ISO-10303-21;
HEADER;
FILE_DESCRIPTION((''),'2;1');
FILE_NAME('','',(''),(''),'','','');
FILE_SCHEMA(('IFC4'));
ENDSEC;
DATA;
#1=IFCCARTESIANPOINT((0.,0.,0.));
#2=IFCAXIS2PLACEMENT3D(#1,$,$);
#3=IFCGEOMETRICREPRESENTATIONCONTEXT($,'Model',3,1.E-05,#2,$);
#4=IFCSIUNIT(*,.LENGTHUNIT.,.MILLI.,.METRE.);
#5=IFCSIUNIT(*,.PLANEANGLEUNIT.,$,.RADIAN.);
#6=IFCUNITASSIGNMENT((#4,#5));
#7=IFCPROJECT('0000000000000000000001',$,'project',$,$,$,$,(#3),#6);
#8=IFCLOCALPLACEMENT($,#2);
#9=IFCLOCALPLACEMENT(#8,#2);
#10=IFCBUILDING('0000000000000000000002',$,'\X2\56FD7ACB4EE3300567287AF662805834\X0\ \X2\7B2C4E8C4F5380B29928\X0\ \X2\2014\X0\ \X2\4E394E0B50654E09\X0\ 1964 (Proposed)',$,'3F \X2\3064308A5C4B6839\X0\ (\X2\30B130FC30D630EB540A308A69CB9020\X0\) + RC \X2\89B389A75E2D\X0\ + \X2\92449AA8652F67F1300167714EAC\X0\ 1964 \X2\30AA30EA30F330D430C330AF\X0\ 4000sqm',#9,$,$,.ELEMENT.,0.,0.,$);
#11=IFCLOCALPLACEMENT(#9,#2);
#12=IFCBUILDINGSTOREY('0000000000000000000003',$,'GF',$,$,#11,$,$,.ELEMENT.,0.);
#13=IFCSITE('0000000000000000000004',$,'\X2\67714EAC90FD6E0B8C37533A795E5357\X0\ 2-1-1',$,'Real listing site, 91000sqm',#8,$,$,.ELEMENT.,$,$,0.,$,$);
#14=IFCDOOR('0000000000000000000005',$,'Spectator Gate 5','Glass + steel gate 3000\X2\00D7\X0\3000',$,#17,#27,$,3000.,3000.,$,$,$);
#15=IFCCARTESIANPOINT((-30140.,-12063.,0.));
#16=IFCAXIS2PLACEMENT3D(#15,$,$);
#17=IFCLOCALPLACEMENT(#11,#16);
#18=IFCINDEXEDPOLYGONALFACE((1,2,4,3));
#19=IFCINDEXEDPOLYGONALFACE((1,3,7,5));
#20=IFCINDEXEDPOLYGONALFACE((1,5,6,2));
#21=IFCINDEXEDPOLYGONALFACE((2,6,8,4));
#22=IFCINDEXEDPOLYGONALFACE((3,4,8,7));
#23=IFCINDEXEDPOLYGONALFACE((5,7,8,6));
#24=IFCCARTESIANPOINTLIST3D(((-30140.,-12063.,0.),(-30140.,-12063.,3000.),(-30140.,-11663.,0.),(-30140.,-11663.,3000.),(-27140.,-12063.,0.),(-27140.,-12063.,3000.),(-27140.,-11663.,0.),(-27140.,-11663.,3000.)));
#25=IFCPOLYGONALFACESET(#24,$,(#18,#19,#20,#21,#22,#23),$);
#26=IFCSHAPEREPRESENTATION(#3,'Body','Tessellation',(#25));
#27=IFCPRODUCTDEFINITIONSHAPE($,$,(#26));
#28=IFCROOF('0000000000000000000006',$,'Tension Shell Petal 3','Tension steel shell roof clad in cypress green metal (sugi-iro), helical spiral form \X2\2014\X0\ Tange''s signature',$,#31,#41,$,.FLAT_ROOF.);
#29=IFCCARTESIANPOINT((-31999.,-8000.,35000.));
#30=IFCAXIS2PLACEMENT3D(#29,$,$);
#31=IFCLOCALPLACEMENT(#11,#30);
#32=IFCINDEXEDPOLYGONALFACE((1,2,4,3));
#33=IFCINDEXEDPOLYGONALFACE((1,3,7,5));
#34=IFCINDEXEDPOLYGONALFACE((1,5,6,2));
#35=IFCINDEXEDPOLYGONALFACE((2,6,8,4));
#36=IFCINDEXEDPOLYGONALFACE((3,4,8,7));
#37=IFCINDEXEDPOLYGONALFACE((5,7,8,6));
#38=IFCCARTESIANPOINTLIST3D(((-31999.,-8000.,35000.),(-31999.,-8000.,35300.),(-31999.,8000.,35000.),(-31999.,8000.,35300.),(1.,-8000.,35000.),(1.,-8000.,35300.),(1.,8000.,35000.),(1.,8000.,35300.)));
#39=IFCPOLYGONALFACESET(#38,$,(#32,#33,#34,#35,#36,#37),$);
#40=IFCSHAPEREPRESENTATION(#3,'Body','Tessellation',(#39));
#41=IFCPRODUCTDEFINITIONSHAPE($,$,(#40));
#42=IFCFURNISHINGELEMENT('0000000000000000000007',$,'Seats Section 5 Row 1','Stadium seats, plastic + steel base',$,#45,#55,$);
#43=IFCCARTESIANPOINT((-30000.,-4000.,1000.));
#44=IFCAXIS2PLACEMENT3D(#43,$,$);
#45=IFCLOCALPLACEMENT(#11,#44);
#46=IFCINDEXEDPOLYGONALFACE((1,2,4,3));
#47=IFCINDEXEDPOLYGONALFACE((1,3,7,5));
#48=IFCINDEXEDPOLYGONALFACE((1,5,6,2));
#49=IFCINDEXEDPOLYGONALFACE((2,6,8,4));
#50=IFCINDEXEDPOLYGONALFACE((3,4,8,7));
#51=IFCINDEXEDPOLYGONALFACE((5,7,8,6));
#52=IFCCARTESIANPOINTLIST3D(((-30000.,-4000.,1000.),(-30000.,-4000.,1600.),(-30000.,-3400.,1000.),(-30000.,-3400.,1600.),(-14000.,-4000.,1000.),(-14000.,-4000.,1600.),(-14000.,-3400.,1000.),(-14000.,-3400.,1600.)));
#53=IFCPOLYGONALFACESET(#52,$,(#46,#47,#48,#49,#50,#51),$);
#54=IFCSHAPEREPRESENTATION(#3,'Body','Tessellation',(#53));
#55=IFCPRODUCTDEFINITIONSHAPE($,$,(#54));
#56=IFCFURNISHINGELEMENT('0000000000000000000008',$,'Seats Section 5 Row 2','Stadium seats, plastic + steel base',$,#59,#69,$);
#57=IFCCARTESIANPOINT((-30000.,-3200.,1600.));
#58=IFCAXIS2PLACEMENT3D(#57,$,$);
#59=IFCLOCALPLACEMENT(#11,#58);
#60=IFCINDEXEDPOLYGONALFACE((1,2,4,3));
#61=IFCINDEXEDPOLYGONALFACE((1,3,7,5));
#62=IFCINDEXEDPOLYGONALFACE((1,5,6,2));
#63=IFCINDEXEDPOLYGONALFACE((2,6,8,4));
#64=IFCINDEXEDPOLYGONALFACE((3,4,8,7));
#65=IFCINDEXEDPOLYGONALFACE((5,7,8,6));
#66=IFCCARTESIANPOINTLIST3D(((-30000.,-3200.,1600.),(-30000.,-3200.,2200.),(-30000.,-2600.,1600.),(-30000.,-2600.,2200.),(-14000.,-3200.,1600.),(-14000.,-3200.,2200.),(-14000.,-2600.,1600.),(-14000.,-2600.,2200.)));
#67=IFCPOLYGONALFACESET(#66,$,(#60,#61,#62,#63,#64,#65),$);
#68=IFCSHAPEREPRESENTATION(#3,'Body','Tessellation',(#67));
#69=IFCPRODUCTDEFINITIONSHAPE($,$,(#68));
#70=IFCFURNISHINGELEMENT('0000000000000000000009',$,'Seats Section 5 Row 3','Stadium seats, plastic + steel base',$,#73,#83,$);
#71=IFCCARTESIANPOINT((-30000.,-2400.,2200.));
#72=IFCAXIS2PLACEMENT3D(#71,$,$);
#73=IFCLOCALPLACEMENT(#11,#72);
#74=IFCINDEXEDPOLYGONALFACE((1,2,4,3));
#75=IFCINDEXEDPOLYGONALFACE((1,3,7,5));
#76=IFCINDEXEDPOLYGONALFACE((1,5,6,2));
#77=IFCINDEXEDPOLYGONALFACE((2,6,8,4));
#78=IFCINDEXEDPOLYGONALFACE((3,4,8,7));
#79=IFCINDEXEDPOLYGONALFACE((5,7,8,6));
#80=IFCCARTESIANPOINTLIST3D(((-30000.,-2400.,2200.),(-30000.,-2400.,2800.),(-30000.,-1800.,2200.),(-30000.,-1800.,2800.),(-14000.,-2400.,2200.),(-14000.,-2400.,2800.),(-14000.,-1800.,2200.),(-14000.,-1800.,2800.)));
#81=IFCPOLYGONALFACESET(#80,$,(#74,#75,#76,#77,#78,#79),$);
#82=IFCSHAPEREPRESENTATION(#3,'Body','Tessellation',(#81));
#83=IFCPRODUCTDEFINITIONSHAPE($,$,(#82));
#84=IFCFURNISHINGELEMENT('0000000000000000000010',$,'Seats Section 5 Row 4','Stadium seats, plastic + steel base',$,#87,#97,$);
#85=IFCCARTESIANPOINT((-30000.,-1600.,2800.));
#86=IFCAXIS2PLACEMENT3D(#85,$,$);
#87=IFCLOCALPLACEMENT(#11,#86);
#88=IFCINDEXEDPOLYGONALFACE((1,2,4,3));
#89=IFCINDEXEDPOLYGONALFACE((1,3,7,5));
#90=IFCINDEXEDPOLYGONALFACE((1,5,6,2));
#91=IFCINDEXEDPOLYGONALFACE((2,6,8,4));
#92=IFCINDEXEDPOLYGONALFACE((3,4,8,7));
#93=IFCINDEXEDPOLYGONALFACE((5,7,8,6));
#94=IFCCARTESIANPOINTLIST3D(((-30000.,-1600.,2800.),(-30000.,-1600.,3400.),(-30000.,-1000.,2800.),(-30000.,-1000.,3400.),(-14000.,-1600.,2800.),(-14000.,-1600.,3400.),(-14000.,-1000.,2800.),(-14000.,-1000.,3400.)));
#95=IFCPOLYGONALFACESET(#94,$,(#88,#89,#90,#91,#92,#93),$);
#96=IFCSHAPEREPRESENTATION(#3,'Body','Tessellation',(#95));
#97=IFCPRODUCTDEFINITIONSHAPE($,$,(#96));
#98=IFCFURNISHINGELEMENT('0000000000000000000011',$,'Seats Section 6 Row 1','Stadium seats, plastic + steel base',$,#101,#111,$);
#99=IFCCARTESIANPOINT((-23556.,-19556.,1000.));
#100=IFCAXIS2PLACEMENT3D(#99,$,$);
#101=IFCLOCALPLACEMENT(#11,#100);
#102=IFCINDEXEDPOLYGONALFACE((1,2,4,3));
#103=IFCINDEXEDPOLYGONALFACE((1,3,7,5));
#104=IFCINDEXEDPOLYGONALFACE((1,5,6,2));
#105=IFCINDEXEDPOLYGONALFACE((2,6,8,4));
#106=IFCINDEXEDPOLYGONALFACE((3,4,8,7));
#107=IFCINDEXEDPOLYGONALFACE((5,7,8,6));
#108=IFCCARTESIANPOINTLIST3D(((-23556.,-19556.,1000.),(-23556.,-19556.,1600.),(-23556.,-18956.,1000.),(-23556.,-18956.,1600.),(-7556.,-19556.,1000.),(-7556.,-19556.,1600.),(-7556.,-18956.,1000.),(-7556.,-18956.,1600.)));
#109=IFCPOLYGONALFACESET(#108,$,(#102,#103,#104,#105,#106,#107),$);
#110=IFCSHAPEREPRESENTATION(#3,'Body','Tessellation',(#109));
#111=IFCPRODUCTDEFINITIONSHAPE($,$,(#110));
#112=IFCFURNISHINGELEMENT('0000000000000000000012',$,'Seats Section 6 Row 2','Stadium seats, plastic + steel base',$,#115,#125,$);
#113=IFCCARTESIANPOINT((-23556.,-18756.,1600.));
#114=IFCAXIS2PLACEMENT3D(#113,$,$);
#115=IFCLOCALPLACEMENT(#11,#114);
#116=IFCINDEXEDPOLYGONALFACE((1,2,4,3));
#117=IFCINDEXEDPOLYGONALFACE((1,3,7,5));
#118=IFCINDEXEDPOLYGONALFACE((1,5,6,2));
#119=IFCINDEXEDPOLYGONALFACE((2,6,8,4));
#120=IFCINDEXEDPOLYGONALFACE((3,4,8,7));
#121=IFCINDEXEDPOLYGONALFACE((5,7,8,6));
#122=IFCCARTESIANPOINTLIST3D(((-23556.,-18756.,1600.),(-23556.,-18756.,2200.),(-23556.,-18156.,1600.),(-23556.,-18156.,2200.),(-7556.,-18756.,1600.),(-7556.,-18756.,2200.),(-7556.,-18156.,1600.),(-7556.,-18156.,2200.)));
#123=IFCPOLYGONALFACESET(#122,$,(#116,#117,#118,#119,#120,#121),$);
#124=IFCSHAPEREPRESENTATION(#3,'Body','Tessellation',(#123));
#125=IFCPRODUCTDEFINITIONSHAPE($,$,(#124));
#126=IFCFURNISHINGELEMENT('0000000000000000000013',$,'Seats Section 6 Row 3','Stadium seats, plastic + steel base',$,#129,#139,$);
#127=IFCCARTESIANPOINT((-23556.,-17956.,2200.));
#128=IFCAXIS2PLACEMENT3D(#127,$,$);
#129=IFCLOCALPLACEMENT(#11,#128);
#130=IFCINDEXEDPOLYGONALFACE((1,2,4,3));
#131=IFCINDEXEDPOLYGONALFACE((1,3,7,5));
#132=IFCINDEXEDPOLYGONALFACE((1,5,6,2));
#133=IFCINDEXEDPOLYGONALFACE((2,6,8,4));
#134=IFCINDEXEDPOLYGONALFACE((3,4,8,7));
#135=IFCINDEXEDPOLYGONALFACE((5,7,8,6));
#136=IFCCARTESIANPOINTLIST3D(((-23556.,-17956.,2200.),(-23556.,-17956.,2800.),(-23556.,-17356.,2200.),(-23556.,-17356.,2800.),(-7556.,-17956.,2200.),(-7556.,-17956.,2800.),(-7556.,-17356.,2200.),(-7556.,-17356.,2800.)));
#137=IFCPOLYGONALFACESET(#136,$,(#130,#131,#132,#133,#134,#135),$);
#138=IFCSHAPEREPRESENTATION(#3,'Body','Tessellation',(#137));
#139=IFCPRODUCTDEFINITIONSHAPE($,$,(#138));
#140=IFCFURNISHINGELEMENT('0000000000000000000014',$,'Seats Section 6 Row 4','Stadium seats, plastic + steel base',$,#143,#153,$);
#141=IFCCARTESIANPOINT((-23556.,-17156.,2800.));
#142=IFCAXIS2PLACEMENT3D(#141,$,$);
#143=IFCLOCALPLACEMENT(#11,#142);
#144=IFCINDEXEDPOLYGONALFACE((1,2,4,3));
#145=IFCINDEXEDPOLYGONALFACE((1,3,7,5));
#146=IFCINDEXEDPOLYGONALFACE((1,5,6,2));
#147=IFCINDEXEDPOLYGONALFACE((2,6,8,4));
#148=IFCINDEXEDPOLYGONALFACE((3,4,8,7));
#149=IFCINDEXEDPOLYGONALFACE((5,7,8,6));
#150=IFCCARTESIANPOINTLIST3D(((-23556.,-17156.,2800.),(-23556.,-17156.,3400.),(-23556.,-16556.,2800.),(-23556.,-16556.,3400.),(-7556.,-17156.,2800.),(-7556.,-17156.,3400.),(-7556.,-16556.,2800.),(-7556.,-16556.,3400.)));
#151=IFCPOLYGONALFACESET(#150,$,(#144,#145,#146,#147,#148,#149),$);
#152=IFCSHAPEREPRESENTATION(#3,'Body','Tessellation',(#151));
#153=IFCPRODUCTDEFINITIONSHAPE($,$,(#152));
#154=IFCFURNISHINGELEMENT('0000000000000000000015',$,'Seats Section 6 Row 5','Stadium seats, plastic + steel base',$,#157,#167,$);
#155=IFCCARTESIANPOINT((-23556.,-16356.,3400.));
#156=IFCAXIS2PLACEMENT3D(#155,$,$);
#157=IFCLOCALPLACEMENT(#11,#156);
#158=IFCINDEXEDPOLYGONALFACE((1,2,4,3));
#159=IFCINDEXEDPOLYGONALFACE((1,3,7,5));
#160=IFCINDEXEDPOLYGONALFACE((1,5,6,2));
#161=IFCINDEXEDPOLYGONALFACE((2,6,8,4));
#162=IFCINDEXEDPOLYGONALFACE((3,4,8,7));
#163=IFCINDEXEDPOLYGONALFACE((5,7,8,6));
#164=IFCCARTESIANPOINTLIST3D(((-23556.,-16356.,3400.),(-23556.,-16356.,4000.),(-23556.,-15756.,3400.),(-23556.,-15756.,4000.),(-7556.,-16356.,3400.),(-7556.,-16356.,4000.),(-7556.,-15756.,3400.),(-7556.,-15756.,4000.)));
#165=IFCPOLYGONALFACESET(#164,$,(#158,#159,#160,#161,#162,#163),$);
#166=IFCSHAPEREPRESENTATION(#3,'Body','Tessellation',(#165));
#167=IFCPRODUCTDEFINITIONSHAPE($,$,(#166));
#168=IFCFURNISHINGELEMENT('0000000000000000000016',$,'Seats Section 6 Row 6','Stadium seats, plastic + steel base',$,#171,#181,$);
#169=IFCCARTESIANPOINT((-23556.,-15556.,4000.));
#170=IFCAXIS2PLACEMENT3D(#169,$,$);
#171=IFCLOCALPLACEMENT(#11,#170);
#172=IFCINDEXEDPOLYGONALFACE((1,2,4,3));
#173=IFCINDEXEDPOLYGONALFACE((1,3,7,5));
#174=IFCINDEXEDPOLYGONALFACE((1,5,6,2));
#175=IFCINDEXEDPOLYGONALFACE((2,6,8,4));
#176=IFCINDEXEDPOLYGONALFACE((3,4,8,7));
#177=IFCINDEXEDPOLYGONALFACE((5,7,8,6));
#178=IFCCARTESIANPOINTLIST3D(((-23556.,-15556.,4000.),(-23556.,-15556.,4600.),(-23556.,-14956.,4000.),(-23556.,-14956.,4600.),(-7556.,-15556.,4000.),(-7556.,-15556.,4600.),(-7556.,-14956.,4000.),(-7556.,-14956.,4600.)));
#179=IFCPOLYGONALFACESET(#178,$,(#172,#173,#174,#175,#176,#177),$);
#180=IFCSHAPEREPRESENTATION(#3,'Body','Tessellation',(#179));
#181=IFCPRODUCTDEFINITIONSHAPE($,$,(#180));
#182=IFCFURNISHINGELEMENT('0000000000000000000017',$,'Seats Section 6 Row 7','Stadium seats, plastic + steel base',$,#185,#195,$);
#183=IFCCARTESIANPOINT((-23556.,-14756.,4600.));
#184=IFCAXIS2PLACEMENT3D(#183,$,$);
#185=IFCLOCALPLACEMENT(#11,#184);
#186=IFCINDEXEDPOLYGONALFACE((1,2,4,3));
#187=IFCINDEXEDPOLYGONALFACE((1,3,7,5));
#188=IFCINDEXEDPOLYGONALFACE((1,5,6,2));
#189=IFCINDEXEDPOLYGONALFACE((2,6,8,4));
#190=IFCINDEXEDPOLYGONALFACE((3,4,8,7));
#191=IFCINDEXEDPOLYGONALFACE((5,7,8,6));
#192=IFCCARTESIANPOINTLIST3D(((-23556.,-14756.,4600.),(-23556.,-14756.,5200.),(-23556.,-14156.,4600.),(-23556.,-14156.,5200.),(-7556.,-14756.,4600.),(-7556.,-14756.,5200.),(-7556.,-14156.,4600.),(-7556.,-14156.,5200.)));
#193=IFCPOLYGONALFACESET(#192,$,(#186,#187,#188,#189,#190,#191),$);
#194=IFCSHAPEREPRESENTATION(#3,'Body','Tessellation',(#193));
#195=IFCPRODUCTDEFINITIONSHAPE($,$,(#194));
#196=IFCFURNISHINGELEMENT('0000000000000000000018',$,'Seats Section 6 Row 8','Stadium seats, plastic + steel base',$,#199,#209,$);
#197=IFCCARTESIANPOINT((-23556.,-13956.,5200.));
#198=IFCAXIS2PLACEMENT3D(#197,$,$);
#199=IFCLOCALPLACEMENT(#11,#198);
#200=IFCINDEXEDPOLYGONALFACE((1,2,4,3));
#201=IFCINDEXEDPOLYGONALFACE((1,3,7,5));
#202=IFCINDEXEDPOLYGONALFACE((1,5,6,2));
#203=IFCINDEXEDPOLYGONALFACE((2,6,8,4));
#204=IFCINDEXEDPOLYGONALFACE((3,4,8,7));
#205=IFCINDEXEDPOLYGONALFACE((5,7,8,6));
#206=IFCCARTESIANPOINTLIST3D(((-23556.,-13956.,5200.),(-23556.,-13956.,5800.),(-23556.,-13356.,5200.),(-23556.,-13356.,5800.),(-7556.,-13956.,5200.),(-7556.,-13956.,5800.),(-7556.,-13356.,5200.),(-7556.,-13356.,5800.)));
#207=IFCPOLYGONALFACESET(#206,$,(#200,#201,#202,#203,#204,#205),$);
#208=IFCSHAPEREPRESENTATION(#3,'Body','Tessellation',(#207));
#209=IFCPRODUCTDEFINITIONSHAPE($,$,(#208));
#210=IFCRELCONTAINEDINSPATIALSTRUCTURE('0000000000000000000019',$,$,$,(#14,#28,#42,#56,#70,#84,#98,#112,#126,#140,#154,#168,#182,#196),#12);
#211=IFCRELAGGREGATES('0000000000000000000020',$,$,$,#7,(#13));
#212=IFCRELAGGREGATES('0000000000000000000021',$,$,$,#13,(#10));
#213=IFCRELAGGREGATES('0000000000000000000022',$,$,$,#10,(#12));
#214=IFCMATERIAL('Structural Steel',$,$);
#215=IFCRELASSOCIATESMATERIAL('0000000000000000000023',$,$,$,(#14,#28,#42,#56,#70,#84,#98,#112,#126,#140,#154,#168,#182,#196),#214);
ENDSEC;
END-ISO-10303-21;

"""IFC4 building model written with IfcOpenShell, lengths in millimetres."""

from ifc_helpers import new_model, si_unit, frame, frame_2d, origin, place, context, project, spatial, rectangle, extrude, material, element, save


model = new_model("IFC4")

# Units and contexts
model_context = context("Model", 3, precision=1e-05, world=origin())
ifc_project = project(units=[si_unit("LENGTHUNIT", "METRE", prefix="MILLI"), si_unit("PLANEANGLEUNIT", "RADIAN")], contexts=[model_context])

# Site, building, storey
site_placement = place(None, origin())
site = spatial("IfcSite", under=ifc_project, at=site_placement, Name="東京都渋谷区神南 2-1-1", ObjectType="Real listing site, 91000sqm", CompositionType="ELEMENT", RefElevation=0.0)
building_placement = place(site_placement, origin())
building = spatial("IfcBuilding", under=site, at=building_placement, Name="国立代々木競技場 第二体育館 — 丹下健三 1964 (Proposed)", ObjectType="3F つり屋根 (ケーブル吊り構造) + RC 観覧席 + 鉄骨支柱、東京 1964 オリンピック 4000sqm", CompositionType="ELEMENT", ElevationOfRefHeight=0.0, ElevationOfTerrain=0.0)
storey_placement = place(building_placement, origin())
storey = spatial("IfcBuildingStorey", under=building, at=storey_placement, Name="GF", CompositionType="ELEMENT", Elevation=0.0)

# Door
ifc_material_1 = material(Name="Structural Steel")
door_placement = place(storey_placement, frame((-30140.0, -12063.0, 0.0)))
element("IfcDoor", 1, at=door_placement, inside=storey, material=ifc_material_1, Name="Spectator Gate 5", Description="Glass + steel gate 3000×3000", OverallHeight=3000.0, OverallWidth=3000.0, context=model_context, shape_type="SweptSolid", body=[
    extrude(rectangle(XDim=3000.0, YDim=400.0, at=frame_2d((1500.0, 200.0))), frame((-30140.0, -12063.0, 0.0)), (0.0, 0.0, 1.0), 3000.0),
])

# Roof
roof_placement = place(storey_placement, frame((-31999.0, -8000.0, 35000.0)))
element("IfcRoof", 2, at=roof_placement, inside=storey, material=ifc_material_1, Name="Tension Shell Petal 3", Description="Tension steel shell roof clad in cypress green metal (sugi-iro), helical spiral form — Tange's signature", PredefinedType="FLAT_ROOF", context=model_context, shape_type="SweptSolid", body=[
    extrude(rectangle(XDim=32000.0, YDim=16000.0, at=frame_2d((16000.0, 8000.0))), frame((-31999.0, -8000.0, 35000.0)), (0.0, 0.0, 1.0), 300.0),
])

# Furnishing elements
furnishing_1_placement = place(storey_placement, frame((-30000.0, -4000.0, 1000.0)))
element("IfcFurnishingElement", 3, at=furnishing_1_placement, inside=storey, material=ifc_material_1, Name="Seats Section 5 Row 1", Description="Stadium seats, plastic + steel base", context=model_context, shape_type="SweptSolid", body=[
    extrude(rectangle(XDim=16000.0, YDim=600.0, at=frame_2d((8000.0, 300.0))), frame((-30000.0, -4000.0, 1000.0)), (0.0, 0.0, 1.0), 600.0),
])
furnishing_2_placement = place(storey_placement, frame((-30000.0, -3200.0, 1600.0)))
element("IfcFurnishingElement", 4, at=furnishing_2_placement, inside=storey, material=ifc_material_1, Name="Seats Section 5 Row 2", Description="Stadium seats, plastic + steel base", context=model_context, shape_type="SweptSolid", body=[
    extrude(rectangle(XDim=16000.0, YDim=600.0, at=frame_2d((8000.0, 300.0))), frame((-30000.0, -3200.0, 1600.0)), (0.0, 0.0, 1.0), 600.0),
])
furnishing_3_placement = place(storey_placement, frame((-30000.0, -2400.0, 2200.0)))
element("IfcFurnishingElement", 5, at=furnishing_3_placement, inside=storey, material=ifc_material_1, Name="Seats Section 5 Row 3", Description="Stadium seats, plastic + steel base", context=model_context, shape_type="SweptSolid", body=[
    extrude(rectangle(XDim=16000.0, YDim=600.0, at=frame_2d((8000.0, 300.0))), frame((-30000.0, -2400.0, 2200.0)), (0.0, 0.0, 1.0), 600.0),
])
furnishing_4_placement = place(storey_placement, frame((-30000.0, -1600.0, 2800.0)))
element("IfcFurnishingElement", 6, at=furnishing_4_placement, inside=storey, material=ifc_material_1, Name="Seats Section 5 Row 4", Description="Stadium seats, plastic + steel base", context=model_context, shape_type="SweptSolid", body=[
    extrude(rectangle(XDim=16000.0, YDim=600.0, at=frame_2d((8000.0, 300.0))), frame((-30000.0, -1600.0, 2800.0)), (0.0, 0.0, 1.0), 600.0),
])
furnishing_5_placement = place(storey_placement, frame((-23556.0, -19556.0, 1000.0)))
element("IfcFurnishingElement", 7, at=furnishing_5_placement, inside=storey, material=ifc_material_1, Name="Seats Section 6 Row 1", Description="Stadium seats, plastic + steel base", context=model_context, shape_type="SweptSolid", body=[
    extrude(rectangle(XDim=16000.0, YDim=600.0, at=frame_2d((8000.0, 300.0))), frame((-23556.0, -19556.0, 1000.0)), (0.0, 0.0, 1.0), 600.0),
])
furnishing_6_placement = place(storey_placement, frame((-23556.0, -18756.0, 1600.0)))
element("IfcFurnishingElement", 8, at=furnishing_6_placement, inside=storey, material=ifc_material_1, Name="Seats Section 6 Row 2", Description="Stadium seats, plastic + steel base", context=model_context, shape_type="SweptSolid", body=[
    extrude(rectangle(XDim=16000.0, YDim=600.0, at=frame_2d((8000.0, 300.0))), frame((-23556.0, -18756.0, 1600.0)), (0.0, 0.0, 1.0), 600.0),
])
furnishing_7_placement = place(storey_placement, frame((-23556.0, -17956.0, 2200.0)))
element("IfcFurnishingElement", 9, at=furnishing_7_placement, inside=storey, material=ifc_material_1, Name="Seats Section 6 Row 3", Description="Stadium seats, plastic + steel base", context=model_context, shape_type="SweptSolid", body=[
    extrude(rectangle(XDim=16000.0, YDim=600.0, at=frame_2d((8000.0, 300.0))), frame((-23556.0, -17956.0, 2200.0)), (0.0, 0.0, 1.0), 600.0),
])
furnishing_8_placement = place(storey_placement, frame((-23556.0, -17156.0, 2800.0)))
element("IfcFurnishingElement", 10, at=furnishing_8_placement, inside=storey, material=ifc_material_1, Name="Seats Section 6 Row 4", Description="Stadium seats, plastic + steel base", context=model_context, shape_type="SweptSolid", body=[
    extrude(rectangle(XDim=16000.0, YDim=600.0, at=frame_2d((8000.0, 300.0))), frame((-23556.0, -17156.0, 2800.0)), (0.0, 0.0, 1.0), 600.0),
])
furnishing_9_placement = place(storey_placement, frame((-23556.0, -16356.0, 3400.0)))
element("IfcFurnishingElement", 11, at=furnishing_9_placement, inside=storey, material=ifc_material_1, Name="Seats Section 6 Row 5", Description="Stadium seats, plastic + steel base", context=model_context, shape_type="SweptSolid", body=[
    extrude(rectangle(XDim=16000.0, YDim=600.0, at=frame_2d((8000.0, 300.0))), frame((-23556.0, -16356.0, 3400.0)), (0.0, 0.0, 1.0), 600.0),
])
furnishing_10_placement = place(storey_placement, frame((-23556.0, -15556.0, 4000.0)))
element("IfcFurnishingElement", 12, at=furnishing_10_placement, inside=storey, material=ifc_material_1, Name="Seats Section 6 Row 6", Description="Stadium seats, plastic + steel base", context=model_context, shape_type="SweptSolid", body=[
    extrude(rectangle(XDim=16000.0, YDim=600.0, at=frame_2d((8000.0, 300.0))), frame((-23556.0, -15556.0, 4000.0)), (0.0, 0.0, 1.0), 600.0),
])
furnishing_11_placement = place(storey_placement, frame((-23556.0, -14756.0, 4600.0)))
element("IfcFurnishingElement", 13, at=furnishing_11_placement, inside=storey, material=ifc_material_1, Name="Seats Section 6 Row 7", Description="Stadium seats, plastic + steel base", context=model_context, shape_type="SweptSolid", body=[
    extrude(rectangle(XDim=16000.0, YDim=600.0, at=frame_2d((8000.0, 300.0))), frame((-23556.0, -14756.0, 4600.0)), (0.0, 0.0, 1.0), 600.0),
])
furnishing_12_placement = place(storey_placement, frame((-23556.0, -13956.0, 5200.0)))
element("IfcFurnishingElement", 14, at=furnishing_12_placement, inside=storey, material=ifc_material_1, Name="Seats Section 6 Row 8", Description="Stadium seats, plastic + steel base", context=model_context, shape_type="SweptSolid", body=[
    extrude(rectangle(XDim=16000.0, YDim=600.0, at=frame_2d((8000.0, 300.0))), frame((-23556.0, -13956.0, 5200.0)), (0.0, 0.0, 1.0), 600.0),
])

save(model, "model.ifc")
